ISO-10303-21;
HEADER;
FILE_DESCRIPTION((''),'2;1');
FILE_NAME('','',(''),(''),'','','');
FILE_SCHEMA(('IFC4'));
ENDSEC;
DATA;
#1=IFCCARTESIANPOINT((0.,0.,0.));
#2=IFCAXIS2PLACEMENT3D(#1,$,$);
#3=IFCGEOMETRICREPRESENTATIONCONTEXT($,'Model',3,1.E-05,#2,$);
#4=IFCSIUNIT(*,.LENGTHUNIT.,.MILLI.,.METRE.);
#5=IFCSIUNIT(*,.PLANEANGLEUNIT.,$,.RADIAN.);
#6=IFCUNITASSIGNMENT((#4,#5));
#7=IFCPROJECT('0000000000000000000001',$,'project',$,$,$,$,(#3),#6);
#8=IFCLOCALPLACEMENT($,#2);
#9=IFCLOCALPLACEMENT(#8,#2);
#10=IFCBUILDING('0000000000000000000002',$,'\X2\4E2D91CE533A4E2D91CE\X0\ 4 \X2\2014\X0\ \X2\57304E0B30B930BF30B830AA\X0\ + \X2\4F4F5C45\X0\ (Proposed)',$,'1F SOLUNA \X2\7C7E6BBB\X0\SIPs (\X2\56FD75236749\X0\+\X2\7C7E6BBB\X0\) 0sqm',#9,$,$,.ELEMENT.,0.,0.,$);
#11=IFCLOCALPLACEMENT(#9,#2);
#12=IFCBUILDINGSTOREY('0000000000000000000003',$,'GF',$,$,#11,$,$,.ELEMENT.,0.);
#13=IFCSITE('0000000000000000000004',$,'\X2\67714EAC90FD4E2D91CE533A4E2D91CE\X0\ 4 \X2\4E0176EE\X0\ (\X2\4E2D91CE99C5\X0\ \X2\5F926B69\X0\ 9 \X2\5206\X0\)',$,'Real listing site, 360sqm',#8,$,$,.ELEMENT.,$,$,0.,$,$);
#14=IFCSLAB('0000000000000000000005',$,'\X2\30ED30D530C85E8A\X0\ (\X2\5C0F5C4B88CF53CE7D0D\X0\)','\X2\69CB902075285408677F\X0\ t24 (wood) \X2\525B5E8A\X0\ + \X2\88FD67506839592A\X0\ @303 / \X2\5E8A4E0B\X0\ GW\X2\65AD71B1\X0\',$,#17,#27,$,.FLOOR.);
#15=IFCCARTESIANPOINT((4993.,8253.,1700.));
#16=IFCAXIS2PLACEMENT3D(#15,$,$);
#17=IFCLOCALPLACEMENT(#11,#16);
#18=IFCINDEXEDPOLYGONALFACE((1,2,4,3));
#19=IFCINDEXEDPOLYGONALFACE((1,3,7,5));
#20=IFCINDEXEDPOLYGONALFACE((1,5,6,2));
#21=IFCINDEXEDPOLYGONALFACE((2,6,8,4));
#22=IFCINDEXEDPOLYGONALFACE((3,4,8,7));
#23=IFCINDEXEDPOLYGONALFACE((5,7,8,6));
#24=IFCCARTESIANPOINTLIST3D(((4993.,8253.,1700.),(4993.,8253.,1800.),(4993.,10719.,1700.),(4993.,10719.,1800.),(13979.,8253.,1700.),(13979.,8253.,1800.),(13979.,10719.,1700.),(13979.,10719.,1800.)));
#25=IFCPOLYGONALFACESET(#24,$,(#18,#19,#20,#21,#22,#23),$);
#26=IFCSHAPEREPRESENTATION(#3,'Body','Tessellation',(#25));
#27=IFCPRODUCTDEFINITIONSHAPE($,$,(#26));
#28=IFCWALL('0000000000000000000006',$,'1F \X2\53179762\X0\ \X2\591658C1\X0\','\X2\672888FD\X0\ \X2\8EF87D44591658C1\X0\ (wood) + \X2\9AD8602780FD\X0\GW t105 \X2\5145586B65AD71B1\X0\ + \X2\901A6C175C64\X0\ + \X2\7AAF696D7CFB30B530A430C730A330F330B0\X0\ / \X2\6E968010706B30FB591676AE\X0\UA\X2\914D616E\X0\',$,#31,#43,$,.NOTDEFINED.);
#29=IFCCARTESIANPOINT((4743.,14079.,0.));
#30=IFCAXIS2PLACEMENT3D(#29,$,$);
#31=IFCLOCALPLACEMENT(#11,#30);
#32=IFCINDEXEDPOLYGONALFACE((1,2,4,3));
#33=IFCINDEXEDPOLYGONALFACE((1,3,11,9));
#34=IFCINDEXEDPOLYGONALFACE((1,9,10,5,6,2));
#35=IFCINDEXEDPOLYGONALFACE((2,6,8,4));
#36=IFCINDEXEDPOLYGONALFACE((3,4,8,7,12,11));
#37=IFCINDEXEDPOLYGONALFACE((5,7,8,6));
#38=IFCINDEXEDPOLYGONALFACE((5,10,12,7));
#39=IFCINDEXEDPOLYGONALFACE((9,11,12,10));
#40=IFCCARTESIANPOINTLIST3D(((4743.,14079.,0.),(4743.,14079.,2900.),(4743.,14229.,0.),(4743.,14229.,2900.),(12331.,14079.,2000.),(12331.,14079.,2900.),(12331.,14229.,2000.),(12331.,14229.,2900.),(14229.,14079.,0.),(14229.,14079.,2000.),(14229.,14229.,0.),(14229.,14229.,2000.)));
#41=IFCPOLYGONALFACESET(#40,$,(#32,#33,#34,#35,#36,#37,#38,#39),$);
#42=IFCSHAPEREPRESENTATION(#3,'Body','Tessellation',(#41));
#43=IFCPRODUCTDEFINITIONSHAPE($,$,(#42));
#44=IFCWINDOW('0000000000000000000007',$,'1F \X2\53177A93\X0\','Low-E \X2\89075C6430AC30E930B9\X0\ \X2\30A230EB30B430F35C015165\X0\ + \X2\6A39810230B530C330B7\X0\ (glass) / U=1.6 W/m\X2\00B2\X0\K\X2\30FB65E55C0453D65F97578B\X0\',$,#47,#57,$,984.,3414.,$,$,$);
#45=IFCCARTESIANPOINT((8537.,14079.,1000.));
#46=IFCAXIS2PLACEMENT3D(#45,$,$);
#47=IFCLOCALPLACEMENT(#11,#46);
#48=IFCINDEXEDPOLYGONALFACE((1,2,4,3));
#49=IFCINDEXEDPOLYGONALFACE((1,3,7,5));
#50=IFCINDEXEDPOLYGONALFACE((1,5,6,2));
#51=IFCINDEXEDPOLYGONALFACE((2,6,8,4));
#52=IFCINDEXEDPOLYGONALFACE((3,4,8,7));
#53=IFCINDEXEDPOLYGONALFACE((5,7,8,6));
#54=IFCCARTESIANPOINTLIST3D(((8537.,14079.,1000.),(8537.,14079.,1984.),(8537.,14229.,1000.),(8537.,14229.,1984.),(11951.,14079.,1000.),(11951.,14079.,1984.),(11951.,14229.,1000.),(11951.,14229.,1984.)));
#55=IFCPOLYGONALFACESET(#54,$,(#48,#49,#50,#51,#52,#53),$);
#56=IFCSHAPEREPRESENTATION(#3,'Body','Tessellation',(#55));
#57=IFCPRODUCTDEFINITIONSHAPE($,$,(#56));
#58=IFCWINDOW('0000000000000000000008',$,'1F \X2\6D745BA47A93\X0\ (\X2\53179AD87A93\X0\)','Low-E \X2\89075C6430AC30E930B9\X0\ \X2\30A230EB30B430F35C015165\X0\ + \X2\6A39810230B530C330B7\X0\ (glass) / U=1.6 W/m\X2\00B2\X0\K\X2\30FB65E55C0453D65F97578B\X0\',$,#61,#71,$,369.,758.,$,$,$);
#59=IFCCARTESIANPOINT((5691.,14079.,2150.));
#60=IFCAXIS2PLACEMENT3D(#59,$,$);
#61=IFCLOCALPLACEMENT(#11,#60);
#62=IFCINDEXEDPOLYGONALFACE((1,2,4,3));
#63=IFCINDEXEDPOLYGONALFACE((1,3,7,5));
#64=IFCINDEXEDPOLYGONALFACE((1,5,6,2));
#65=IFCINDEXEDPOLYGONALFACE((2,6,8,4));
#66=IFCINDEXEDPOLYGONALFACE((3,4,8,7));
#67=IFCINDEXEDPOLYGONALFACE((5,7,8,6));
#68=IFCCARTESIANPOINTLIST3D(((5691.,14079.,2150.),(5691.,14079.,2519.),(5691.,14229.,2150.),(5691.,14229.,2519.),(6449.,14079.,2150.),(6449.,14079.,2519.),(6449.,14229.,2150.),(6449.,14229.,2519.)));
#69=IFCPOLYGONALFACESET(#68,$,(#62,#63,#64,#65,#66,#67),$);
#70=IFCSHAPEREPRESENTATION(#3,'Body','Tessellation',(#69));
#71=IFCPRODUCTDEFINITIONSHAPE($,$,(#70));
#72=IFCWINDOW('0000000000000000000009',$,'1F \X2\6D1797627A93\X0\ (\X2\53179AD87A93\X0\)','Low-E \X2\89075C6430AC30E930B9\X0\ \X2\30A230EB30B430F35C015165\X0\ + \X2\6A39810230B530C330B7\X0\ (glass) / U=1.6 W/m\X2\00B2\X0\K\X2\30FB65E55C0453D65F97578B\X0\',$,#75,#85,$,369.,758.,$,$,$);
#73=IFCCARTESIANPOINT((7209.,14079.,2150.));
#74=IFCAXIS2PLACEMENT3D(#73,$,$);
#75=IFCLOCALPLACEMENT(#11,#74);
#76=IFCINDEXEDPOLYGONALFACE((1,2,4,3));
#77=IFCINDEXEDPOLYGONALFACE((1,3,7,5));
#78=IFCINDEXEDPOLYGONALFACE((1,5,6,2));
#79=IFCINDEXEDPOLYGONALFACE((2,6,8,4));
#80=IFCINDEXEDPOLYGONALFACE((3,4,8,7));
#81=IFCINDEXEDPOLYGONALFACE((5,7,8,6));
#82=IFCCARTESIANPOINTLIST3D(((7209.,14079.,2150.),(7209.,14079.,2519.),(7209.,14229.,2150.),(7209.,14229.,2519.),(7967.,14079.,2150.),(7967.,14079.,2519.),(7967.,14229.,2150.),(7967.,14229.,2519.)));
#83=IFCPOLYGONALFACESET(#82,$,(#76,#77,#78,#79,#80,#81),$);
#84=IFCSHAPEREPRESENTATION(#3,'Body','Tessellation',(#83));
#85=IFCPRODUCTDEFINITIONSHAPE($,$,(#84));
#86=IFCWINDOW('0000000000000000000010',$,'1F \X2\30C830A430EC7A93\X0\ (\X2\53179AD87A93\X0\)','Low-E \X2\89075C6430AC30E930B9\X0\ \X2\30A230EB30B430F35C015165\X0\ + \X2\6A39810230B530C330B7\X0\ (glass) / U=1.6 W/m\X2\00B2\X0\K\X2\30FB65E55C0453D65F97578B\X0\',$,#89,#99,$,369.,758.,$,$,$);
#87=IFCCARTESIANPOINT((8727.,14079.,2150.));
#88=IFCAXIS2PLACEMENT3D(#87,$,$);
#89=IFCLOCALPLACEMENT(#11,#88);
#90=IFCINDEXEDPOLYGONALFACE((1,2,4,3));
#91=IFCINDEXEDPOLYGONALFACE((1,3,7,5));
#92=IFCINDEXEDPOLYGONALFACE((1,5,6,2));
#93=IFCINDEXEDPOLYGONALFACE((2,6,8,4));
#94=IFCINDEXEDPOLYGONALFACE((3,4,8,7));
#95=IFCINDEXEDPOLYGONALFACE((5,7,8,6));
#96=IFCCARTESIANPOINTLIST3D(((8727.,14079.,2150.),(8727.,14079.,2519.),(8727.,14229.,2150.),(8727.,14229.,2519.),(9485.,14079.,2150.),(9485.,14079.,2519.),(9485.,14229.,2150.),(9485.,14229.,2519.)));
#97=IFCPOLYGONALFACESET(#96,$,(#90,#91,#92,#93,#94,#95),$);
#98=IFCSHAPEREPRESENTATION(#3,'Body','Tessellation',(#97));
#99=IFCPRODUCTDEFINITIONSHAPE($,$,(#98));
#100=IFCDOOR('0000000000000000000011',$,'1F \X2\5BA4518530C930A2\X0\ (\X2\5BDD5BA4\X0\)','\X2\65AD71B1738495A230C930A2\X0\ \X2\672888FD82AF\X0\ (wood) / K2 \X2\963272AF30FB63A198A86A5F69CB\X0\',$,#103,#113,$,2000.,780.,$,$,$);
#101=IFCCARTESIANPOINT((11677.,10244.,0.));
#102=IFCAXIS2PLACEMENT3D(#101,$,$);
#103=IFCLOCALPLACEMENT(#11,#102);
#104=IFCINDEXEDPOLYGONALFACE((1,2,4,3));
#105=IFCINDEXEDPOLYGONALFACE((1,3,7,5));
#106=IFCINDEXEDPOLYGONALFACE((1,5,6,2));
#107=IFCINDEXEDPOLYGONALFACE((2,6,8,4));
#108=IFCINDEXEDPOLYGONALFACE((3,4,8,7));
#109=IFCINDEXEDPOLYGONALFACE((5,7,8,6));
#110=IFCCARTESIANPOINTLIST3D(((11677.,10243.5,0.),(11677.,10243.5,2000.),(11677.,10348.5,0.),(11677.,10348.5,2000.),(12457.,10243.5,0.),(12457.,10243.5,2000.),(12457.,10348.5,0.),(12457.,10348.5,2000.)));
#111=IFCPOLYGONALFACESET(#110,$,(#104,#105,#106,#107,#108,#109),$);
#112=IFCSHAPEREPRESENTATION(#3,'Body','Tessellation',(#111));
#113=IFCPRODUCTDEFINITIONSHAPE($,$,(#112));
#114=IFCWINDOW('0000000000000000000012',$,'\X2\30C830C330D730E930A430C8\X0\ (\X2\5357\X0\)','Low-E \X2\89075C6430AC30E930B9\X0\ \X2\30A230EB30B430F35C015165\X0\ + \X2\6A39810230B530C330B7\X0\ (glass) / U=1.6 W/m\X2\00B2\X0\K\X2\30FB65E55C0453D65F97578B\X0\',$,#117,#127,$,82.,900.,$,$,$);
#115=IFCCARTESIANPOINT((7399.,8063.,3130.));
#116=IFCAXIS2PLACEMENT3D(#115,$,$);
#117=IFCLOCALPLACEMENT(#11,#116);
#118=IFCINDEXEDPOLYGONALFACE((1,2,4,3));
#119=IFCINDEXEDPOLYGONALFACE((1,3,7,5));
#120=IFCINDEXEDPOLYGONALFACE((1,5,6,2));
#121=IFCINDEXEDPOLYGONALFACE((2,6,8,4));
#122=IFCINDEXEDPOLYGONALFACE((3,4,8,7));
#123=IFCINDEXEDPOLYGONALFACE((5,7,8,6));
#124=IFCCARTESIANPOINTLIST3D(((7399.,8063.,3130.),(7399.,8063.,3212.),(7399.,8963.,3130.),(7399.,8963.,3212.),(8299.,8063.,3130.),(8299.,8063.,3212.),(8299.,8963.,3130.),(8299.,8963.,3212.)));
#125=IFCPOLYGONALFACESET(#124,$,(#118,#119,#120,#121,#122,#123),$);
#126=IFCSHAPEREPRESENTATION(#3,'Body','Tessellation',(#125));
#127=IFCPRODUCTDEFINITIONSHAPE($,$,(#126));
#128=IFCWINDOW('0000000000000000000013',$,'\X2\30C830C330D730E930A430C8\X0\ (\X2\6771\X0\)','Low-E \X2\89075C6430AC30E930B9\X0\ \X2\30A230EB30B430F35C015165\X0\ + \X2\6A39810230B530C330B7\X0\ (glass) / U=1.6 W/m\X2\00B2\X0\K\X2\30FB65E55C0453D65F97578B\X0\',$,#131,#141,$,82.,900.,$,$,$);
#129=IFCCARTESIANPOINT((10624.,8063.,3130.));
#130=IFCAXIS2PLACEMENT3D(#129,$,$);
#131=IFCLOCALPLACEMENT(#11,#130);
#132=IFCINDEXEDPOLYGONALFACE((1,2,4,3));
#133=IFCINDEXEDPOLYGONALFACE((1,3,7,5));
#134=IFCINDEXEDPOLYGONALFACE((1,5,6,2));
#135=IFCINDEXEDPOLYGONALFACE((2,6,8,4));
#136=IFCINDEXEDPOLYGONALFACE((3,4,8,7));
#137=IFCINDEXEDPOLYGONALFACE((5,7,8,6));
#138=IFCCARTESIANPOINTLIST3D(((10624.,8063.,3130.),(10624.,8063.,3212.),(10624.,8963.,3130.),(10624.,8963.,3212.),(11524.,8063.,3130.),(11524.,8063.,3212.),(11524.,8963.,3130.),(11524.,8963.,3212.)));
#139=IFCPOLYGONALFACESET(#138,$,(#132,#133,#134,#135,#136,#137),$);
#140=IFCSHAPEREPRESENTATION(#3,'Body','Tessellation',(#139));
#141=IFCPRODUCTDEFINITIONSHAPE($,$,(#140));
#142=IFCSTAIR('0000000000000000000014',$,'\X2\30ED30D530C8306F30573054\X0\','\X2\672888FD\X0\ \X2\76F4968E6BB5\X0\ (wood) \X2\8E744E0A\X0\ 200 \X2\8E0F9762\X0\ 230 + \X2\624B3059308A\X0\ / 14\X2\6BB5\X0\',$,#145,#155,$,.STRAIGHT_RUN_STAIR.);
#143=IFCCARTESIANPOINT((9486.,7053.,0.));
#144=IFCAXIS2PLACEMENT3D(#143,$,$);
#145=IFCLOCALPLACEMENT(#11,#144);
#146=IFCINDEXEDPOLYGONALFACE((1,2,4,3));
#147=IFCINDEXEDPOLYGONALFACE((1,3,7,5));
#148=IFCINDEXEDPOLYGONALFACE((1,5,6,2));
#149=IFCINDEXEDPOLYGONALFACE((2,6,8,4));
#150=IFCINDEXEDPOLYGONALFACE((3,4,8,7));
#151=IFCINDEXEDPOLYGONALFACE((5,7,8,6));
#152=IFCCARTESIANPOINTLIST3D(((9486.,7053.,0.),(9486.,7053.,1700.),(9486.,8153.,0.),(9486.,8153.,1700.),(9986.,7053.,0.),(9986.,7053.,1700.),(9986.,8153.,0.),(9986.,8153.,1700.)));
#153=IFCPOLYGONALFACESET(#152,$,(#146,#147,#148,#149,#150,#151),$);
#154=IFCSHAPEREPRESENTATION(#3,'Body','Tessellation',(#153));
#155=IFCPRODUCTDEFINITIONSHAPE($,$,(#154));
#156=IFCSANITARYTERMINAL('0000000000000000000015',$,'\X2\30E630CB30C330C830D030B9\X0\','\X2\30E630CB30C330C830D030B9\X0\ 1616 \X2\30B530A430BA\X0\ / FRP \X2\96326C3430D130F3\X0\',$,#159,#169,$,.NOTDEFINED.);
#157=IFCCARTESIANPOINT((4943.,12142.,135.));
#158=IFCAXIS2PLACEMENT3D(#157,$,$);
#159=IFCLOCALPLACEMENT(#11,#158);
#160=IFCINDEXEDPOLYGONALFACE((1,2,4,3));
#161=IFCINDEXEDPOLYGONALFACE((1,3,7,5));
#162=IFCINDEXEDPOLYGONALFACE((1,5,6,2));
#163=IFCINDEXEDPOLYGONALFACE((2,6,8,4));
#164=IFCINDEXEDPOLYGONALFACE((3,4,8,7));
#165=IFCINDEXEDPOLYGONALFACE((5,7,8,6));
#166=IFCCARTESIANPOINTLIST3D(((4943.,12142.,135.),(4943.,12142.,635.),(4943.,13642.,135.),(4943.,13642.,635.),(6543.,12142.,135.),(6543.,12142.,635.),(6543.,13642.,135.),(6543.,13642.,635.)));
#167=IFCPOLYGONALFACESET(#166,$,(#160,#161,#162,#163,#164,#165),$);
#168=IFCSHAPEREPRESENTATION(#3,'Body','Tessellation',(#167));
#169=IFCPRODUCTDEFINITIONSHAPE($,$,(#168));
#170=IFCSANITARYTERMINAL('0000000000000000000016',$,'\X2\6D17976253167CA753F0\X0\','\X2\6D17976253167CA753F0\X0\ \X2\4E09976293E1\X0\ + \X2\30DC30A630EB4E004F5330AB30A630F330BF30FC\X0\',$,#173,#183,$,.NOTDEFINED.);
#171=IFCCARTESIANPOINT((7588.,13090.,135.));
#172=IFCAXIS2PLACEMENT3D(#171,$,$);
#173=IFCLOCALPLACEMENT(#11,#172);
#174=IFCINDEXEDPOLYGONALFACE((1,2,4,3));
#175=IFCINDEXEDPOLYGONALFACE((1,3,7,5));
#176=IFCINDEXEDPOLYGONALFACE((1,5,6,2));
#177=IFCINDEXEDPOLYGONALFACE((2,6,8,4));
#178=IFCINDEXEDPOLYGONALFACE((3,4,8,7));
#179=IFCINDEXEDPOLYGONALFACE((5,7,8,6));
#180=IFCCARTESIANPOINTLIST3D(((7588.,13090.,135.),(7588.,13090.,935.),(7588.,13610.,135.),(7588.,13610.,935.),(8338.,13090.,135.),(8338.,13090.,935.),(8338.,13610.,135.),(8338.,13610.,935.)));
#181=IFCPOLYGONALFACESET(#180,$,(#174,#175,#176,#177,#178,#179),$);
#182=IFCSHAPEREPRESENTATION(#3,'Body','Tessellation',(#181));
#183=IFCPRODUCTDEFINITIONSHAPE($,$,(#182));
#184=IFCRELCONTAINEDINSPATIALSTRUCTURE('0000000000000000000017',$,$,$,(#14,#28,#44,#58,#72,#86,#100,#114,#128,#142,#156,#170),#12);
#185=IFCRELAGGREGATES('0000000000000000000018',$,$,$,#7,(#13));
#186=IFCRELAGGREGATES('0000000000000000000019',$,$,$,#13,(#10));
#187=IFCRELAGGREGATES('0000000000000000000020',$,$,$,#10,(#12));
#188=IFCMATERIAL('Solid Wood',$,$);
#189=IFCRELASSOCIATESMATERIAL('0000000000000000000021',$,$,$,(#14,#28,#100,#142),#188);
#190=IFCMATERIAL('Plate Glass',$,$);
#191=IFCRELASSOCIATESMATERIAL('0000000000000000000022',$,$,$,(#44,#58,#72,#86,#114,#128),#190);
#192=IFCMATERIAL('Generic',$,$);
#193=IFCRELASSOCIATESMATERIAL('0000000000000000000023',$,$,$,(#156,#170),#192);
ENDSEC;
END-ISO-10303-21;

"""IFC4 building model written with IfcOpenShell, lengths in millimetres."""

from ifc_helpers import new_model, si_unit, frame, frame_2d, origin, place, context, project, spatial, rectangle, extrude, material, element, fill, save


model = new_model("IFC4")

# Units and contexts
model_context = context("Model", 3, precision=1e-05, world=origin())
ifc_project = project(units=[si_unit("LENGTHUNIT", "METRE", prefix="MILLI"), si_unit("PLANEANGLEUNIT", "RADIAN")], contexts=[model_context])

# Site, building, storey
site_placement = place(None, origin())
site = spatial("IfcSite", under=ifc_project, at=site_placement, Name="東京都中野区中野 4 丁目 (中野駅 徒歩 9 分)", ObjectType="Real listing site, 360sqm", CompositionType="ELEMENT", RefElevation=0.0)
building_placement = place(site_placement, origin())
building = spatial("IfcBuilding", under=site, at=building_placement, Name="中野区中野 4 — 地下スタジオ + 住居 (Proposed)", ObjectType="1F SOLUNA 籾殻SIPs (国産杉+籾殻) 0sqm", CompositionType="ELEMENT", ElevationOfRefHeight=0.0, ElevationOfTerrain=0.0)
storey_placement = place(building_placement, origin())
storey = spatial("IfcBuildingStorey", under=building, at=storey_placement, Name="GF", CompositionType="ELEMENT", Elevation=0.0)

# Slab
ifc_material_1 = material(Name="Solid Wood")
slab_placement = place(storey_placement, frame((4993.0, 8253.0, 1700.0)))
element("IfcSlab", 1, at=slab_placement, inside=storey, material=ifc_material_1, Name="ロフト床 (小屋裏収納)", Description="構造用合板 t24 (wood) 剛床 + 製材根太 @303 / 床下 GW断熱", PredefinedType="FLOOR", context=model_context, shape_type="SweptSolid", body=[
    extrude(rectangle(XDim=8986.0, YDim=2466.0, at=frame_2d((4493.0, 1233.0))), frame((4993.0, 8253.0, 1700.0)), (0.0, 0.0, 1.0), 100.0),
])

# Wall, openings, windows
wall_1_placement = place(storey_placement, frame((4743.0, 14079.0, 0.0)))
wall_1 = element("IfcWall", 2, at=wall_1_placement, inside=storey, material=ifc_material_1, Name="1F 北面 外壁", Description="木製 軸組外壁 (wood) + 高性能GW t105 充填断熱 + 通気層 + 窯業系サイディング / 準耐火・外皮UA配慮", PredefinedType="NOTDEFINED", context=model_context, shape_type="SweptSolid", body=[
    extrude(rectangle(XDim=9486.0, YDim=150.0, at=frame_2d((4743.0, 75.0))), frame((4743.0, 14079.0, 0.0)), (0.0, 0.0, 1.0), 2900.0),
])
opening_1_placement = place(storey_placement, frame((8537.0, 14079.0, 1000.0)))
opening_1 = element("IfcOpeningElement", 3, at=opening_1_placement, cuts=wall_1, PredefinedType="NOTDEFINED", context=model_context, shape_type="SweptSolid", body=[
    extrude(rectangle(XDim=3414.0, YDim=150.0, at=frame_2d((1707.0, 75.0))), frame((8537.0, 14079.0, 1000.0)), (0.0, 0.0, 1.0), 984.0),
])
opening_2_placement = place(storey_placement, frame((5691.0, 14079.0, 2150.0)))
opening_2 = element("IfcOpeningElement", 4, at=opening_2_placement, cuts=wall_1, PredefinedType="NOTDEFINED", context=model_context, shape_type="SweptSolid", body=[
    extrude(rectangle(XDim=758.0, YDim=150.0, at=frame_2d((379.0, 75.0))), frame((5691.0, 14079.0, 2150.0)), (0.0, 0.0, 1.0), 369.0),
])
opening_3_placement = place(storey_placement, frame((7209.0, 14079.0, 2150.0)))
opening_3 = element("IfcOpeningElement", 5, at=opening_3_placement, cuts=wall_1, PredefinedType="NOTDEFINED", context=model_context, shape_type="SweptSolid", body=[
    extrude(rectangle(XDim=758.0, YDim=150.0, at=frame_2d((379.0, 75.0))), frame((7209.0, 14079.0, 2150.0)), (0.0, 0.0, 1.0), 369.0),
])
opening_4_placement = place(storey_placement, frame((8727.0, 14079.0, 2150.0)))
opening_4 = element("IfcOpeningElement", 6, at=opening_4_placement, cuts=wall_1, PredefinedType="NOTDEFINED", context=model_context, shape_type="SweptSolid", body=[
    extrude(rectangle(XDim=758.0, YDim=150.0, at=frame_2d((379.0, 75.0))), frame((8727.0, 14079.0, 2150.0)), (0.0, 0.0, 1.0), 369.0),
])
ifc_material_2 = material(Name="Plate Glass")
window_1_placement = place(storey_placement, frame((8537.0, 14079.0, 1000.0)))
window_1 = element("IfcWindow", 7, at=window_1_placement, inside=storey, material=ifc_material_2, Name="1F 北窓", Description="Low-E 複層ガラス アルゴン封入 + 樹脂サッシ (glass) / U=1.6 W/m²K・日射取得型", OverallHeight=984.0, OverallWidth=3414.0, context=model_context, shape_type="SweptSolid", body=[
    extrude(rectangle(XDim=3414.0, YDim=150.0, at=frame_2d((1707.0, 75.0))), frame((8537.0, 14079.0, 1000.0)), (0.0, 0.0, 1.0), 984.0),
])
fill(opening_1, window_1)
window_2_placement = place(storey_placement, frame((5691.0, 14079.0, 2150.0)))
window_2 = element("IfcWindow", 8, at=window_2_placement, inside=storey, material=ifc_material_2, Name="1F 浴室窓 (北高窓)", Description="Low-E 複層ガラス アルゴン封入 + 樹脂サッシ (glass) / U=1.6 W/m²K・日射取得型", OverallHeight=369.0, OverallWidth=758.0, context=model_context, shape_type="SweptSolid", body=[
    extrude(rectangle(XDim=758.0, YDim=150.0, at=frame_2d((379.0, 75.0))), frame((5691.0, 14079.0, 2150.0)), (0.0, 0.0, 1.0), 369.0),
])
fill(opening_2, window_2)
window_3_placement = place(storey_placement, frame((7209.0, 14079.0, 2150.0)))
window_3 = element("IfcWindow", 9, at=window_3_placement, inside=storey, material=ifc_material_2, Name="1F 洗面窓 (北高窓)", Description="Low-E 複層ガラス アルゴン封入 + 樹脂サッシ (glass) / U=1.6 W/m²K・日射取得型", OverallHeight=369.0, OverallWidth=758.0, context=model_context, shape_type="SweptSolid", body=[
    extrude(rectangle(XDim=758.0, YDim=150.0, at=frame_2d((379.0, 75.0))), frame((7209.0, 14079.0, 2150.0)), (0.0, 0.0, 1.0), 369.0),
])
fill(opening_3, window_3)
window_4_placement = place(storey_placement, frame((8727.0, 14079.0, 2150.0)))
window_4 = element("IfcWindow", 10, at=window_4_placement, inside=storey, material=ifc_material_2, Name="1F トイレ窓 (北高窓)", Description="Low-E 複層ガラス アルゴン封入 + 樹脂サッシ (glass) / U=1.6 W/m²K・日射取得型", OverallHeight=369.0, OverallWidth=758.0, context=model_context, shape_type="SweptSolid", body=[
    extrude(rectangle(XDim=758.0, YDim=150.0, at=frame_2d((379.0, 75.0))), frame((8727.0, 14079.0, 2150.0)), (0.0, 0.0, 1.0), 369.0),
])
fill(opening_4, window_4)

# Door
door_1_placement = place(storey_placement, frame((11677.0, 10244.0, 0.0)))
element("IfcDoor", 11, at=door_1_placement, inside=storey, material=ifc_material_1, Name="1F 室内ドア (寝室)", Description="断熱玄関ドア 木製芯 (wood) / K2 防犯・採風機構", OverallHeight=2000.0, OverallWidth=780.0, context=model_context, shape_type="SweptSolid", body=[
    extrude(rectangle(XDim=780.0, YDim=105.0, at=frame_2d((390.0, 52.0))), frame((11677.0, 10244.0, 0.0)), (0.0, 0.0, 1.0), 2000.0),
])

# Windows
window_5_placement = place(storey_placement, frame((7399.0, 8063.0, 3130.0)))
element("IfcWindow", 12, at=window_5_placement, inside=storey, material=ifc_material_2, Name="トップライト (南)", Description="Low-E 複層ガラス アルゴン封入 + 樹脂サッシ (glass) / U=1.6 W/m²K・日射取得型", OverallHeight=82.0, OverallWidth=900.0, context=model_context, shape_type="SweptSolid", body=[
    extrude(rectangle(XDim=900.0, YDim=900.0, at=frame_2d((450.0, 450.0))), frame((7399.0, 8063.0, 3130.0)), (0.0, 0.0, 1.0), 82.0),
])
window_6_placement = place(storey_placement, frame((10624.0, 8063.0, 3130.0)))
element("IfcWindow", 13, at=window_6_placement, inside=storey, material=ifc_material_2, Name="トップライト (東)", Description="Low-E 複層ガラス アルゴン封入 + 樹脂サッシ (glass) / U=1.6 W/m²K・日射取得型", OverallHeight=82.0, OverallWidth=900.0, context=model_context, shape_type="SweptSolid", body=[
    extrude(rectangle(XDim=900.0, YDim=900.0, at=frame_2d((450.0, 450.0))), frame((10624.0, 8063.0, 3130.0)), (0.0, 0.0, 1.0), 82.0),
])

# Stair
stair_placement = place(storey_placement, frame((9486.0, 7053.0, 0.0)))
element("IfcStair", 14, at=stair_placement, inside=storey, material=ifc_material_1, Name="ロフトはしご", Description="木製 直階段 (wood) 蹴上 200 踏面 230 + 手すり / 14段", PredefinedType="STRAIGHT_RUN_STAIR", context=model_context, shape_type="SweptSolid", body=[
    extrude(rectangle(XDim=500.0, YDim=1100.0, at=frame_2d((250.0, 550.0))), frame((9486.0, 7053.0, 0.0)), (0.0, 0.0, 1.0), 1700.0),
])

# Sanitary terminals
ifc_material_3 = material(Name="Generic")
sanitary_terminal_1_placement = place(storey_placement, frame((4943.0, 12142.0, 135.0)))
element("IfcSanitaryTerminal", 15, at=sanitary_terminal_1_placement, inside=storey, material=ifc_material_3, Name="ユニットバス", Description="ユニットバス 1616 サイズ / FRP 防水パン", PredefinedType="NOTDEFINED", context=model_context, shape_type="SweptSolid", body=[
    extrude(rectangle(XDim=1600.0, YDim=1500.0, at=frame_2d((800.0, 750.0))), frame((4943.0, 12142.0, 135.0)), (0.0, 0.0, 1.0), 500.0),
])
sanitary_terminal_2_placement = place(storey_placement, frame((7588.0, 13090.0, 135.0)))
element("IfcSanitaryTerminal", 16, at=sanitary_terminal_2_placement, inside=storey, material=ifc_material_3, Name="洗面化粧台", Description="洗面化粧台 三面鏡 + ボウル一体カウンター", PredefinedType="NOTDEFINED", context=model_context, shape_type="SweptSolid", body=[
    extrude(rectangle(XDim=750.0, YDim=520.0, at=frame_2d((375.0, 260.0))), frame((7588.0, 13090.0, 135.0)), (0.0, 0.0, 1.0), 800.0),
])

save(model, "model.ifc")
